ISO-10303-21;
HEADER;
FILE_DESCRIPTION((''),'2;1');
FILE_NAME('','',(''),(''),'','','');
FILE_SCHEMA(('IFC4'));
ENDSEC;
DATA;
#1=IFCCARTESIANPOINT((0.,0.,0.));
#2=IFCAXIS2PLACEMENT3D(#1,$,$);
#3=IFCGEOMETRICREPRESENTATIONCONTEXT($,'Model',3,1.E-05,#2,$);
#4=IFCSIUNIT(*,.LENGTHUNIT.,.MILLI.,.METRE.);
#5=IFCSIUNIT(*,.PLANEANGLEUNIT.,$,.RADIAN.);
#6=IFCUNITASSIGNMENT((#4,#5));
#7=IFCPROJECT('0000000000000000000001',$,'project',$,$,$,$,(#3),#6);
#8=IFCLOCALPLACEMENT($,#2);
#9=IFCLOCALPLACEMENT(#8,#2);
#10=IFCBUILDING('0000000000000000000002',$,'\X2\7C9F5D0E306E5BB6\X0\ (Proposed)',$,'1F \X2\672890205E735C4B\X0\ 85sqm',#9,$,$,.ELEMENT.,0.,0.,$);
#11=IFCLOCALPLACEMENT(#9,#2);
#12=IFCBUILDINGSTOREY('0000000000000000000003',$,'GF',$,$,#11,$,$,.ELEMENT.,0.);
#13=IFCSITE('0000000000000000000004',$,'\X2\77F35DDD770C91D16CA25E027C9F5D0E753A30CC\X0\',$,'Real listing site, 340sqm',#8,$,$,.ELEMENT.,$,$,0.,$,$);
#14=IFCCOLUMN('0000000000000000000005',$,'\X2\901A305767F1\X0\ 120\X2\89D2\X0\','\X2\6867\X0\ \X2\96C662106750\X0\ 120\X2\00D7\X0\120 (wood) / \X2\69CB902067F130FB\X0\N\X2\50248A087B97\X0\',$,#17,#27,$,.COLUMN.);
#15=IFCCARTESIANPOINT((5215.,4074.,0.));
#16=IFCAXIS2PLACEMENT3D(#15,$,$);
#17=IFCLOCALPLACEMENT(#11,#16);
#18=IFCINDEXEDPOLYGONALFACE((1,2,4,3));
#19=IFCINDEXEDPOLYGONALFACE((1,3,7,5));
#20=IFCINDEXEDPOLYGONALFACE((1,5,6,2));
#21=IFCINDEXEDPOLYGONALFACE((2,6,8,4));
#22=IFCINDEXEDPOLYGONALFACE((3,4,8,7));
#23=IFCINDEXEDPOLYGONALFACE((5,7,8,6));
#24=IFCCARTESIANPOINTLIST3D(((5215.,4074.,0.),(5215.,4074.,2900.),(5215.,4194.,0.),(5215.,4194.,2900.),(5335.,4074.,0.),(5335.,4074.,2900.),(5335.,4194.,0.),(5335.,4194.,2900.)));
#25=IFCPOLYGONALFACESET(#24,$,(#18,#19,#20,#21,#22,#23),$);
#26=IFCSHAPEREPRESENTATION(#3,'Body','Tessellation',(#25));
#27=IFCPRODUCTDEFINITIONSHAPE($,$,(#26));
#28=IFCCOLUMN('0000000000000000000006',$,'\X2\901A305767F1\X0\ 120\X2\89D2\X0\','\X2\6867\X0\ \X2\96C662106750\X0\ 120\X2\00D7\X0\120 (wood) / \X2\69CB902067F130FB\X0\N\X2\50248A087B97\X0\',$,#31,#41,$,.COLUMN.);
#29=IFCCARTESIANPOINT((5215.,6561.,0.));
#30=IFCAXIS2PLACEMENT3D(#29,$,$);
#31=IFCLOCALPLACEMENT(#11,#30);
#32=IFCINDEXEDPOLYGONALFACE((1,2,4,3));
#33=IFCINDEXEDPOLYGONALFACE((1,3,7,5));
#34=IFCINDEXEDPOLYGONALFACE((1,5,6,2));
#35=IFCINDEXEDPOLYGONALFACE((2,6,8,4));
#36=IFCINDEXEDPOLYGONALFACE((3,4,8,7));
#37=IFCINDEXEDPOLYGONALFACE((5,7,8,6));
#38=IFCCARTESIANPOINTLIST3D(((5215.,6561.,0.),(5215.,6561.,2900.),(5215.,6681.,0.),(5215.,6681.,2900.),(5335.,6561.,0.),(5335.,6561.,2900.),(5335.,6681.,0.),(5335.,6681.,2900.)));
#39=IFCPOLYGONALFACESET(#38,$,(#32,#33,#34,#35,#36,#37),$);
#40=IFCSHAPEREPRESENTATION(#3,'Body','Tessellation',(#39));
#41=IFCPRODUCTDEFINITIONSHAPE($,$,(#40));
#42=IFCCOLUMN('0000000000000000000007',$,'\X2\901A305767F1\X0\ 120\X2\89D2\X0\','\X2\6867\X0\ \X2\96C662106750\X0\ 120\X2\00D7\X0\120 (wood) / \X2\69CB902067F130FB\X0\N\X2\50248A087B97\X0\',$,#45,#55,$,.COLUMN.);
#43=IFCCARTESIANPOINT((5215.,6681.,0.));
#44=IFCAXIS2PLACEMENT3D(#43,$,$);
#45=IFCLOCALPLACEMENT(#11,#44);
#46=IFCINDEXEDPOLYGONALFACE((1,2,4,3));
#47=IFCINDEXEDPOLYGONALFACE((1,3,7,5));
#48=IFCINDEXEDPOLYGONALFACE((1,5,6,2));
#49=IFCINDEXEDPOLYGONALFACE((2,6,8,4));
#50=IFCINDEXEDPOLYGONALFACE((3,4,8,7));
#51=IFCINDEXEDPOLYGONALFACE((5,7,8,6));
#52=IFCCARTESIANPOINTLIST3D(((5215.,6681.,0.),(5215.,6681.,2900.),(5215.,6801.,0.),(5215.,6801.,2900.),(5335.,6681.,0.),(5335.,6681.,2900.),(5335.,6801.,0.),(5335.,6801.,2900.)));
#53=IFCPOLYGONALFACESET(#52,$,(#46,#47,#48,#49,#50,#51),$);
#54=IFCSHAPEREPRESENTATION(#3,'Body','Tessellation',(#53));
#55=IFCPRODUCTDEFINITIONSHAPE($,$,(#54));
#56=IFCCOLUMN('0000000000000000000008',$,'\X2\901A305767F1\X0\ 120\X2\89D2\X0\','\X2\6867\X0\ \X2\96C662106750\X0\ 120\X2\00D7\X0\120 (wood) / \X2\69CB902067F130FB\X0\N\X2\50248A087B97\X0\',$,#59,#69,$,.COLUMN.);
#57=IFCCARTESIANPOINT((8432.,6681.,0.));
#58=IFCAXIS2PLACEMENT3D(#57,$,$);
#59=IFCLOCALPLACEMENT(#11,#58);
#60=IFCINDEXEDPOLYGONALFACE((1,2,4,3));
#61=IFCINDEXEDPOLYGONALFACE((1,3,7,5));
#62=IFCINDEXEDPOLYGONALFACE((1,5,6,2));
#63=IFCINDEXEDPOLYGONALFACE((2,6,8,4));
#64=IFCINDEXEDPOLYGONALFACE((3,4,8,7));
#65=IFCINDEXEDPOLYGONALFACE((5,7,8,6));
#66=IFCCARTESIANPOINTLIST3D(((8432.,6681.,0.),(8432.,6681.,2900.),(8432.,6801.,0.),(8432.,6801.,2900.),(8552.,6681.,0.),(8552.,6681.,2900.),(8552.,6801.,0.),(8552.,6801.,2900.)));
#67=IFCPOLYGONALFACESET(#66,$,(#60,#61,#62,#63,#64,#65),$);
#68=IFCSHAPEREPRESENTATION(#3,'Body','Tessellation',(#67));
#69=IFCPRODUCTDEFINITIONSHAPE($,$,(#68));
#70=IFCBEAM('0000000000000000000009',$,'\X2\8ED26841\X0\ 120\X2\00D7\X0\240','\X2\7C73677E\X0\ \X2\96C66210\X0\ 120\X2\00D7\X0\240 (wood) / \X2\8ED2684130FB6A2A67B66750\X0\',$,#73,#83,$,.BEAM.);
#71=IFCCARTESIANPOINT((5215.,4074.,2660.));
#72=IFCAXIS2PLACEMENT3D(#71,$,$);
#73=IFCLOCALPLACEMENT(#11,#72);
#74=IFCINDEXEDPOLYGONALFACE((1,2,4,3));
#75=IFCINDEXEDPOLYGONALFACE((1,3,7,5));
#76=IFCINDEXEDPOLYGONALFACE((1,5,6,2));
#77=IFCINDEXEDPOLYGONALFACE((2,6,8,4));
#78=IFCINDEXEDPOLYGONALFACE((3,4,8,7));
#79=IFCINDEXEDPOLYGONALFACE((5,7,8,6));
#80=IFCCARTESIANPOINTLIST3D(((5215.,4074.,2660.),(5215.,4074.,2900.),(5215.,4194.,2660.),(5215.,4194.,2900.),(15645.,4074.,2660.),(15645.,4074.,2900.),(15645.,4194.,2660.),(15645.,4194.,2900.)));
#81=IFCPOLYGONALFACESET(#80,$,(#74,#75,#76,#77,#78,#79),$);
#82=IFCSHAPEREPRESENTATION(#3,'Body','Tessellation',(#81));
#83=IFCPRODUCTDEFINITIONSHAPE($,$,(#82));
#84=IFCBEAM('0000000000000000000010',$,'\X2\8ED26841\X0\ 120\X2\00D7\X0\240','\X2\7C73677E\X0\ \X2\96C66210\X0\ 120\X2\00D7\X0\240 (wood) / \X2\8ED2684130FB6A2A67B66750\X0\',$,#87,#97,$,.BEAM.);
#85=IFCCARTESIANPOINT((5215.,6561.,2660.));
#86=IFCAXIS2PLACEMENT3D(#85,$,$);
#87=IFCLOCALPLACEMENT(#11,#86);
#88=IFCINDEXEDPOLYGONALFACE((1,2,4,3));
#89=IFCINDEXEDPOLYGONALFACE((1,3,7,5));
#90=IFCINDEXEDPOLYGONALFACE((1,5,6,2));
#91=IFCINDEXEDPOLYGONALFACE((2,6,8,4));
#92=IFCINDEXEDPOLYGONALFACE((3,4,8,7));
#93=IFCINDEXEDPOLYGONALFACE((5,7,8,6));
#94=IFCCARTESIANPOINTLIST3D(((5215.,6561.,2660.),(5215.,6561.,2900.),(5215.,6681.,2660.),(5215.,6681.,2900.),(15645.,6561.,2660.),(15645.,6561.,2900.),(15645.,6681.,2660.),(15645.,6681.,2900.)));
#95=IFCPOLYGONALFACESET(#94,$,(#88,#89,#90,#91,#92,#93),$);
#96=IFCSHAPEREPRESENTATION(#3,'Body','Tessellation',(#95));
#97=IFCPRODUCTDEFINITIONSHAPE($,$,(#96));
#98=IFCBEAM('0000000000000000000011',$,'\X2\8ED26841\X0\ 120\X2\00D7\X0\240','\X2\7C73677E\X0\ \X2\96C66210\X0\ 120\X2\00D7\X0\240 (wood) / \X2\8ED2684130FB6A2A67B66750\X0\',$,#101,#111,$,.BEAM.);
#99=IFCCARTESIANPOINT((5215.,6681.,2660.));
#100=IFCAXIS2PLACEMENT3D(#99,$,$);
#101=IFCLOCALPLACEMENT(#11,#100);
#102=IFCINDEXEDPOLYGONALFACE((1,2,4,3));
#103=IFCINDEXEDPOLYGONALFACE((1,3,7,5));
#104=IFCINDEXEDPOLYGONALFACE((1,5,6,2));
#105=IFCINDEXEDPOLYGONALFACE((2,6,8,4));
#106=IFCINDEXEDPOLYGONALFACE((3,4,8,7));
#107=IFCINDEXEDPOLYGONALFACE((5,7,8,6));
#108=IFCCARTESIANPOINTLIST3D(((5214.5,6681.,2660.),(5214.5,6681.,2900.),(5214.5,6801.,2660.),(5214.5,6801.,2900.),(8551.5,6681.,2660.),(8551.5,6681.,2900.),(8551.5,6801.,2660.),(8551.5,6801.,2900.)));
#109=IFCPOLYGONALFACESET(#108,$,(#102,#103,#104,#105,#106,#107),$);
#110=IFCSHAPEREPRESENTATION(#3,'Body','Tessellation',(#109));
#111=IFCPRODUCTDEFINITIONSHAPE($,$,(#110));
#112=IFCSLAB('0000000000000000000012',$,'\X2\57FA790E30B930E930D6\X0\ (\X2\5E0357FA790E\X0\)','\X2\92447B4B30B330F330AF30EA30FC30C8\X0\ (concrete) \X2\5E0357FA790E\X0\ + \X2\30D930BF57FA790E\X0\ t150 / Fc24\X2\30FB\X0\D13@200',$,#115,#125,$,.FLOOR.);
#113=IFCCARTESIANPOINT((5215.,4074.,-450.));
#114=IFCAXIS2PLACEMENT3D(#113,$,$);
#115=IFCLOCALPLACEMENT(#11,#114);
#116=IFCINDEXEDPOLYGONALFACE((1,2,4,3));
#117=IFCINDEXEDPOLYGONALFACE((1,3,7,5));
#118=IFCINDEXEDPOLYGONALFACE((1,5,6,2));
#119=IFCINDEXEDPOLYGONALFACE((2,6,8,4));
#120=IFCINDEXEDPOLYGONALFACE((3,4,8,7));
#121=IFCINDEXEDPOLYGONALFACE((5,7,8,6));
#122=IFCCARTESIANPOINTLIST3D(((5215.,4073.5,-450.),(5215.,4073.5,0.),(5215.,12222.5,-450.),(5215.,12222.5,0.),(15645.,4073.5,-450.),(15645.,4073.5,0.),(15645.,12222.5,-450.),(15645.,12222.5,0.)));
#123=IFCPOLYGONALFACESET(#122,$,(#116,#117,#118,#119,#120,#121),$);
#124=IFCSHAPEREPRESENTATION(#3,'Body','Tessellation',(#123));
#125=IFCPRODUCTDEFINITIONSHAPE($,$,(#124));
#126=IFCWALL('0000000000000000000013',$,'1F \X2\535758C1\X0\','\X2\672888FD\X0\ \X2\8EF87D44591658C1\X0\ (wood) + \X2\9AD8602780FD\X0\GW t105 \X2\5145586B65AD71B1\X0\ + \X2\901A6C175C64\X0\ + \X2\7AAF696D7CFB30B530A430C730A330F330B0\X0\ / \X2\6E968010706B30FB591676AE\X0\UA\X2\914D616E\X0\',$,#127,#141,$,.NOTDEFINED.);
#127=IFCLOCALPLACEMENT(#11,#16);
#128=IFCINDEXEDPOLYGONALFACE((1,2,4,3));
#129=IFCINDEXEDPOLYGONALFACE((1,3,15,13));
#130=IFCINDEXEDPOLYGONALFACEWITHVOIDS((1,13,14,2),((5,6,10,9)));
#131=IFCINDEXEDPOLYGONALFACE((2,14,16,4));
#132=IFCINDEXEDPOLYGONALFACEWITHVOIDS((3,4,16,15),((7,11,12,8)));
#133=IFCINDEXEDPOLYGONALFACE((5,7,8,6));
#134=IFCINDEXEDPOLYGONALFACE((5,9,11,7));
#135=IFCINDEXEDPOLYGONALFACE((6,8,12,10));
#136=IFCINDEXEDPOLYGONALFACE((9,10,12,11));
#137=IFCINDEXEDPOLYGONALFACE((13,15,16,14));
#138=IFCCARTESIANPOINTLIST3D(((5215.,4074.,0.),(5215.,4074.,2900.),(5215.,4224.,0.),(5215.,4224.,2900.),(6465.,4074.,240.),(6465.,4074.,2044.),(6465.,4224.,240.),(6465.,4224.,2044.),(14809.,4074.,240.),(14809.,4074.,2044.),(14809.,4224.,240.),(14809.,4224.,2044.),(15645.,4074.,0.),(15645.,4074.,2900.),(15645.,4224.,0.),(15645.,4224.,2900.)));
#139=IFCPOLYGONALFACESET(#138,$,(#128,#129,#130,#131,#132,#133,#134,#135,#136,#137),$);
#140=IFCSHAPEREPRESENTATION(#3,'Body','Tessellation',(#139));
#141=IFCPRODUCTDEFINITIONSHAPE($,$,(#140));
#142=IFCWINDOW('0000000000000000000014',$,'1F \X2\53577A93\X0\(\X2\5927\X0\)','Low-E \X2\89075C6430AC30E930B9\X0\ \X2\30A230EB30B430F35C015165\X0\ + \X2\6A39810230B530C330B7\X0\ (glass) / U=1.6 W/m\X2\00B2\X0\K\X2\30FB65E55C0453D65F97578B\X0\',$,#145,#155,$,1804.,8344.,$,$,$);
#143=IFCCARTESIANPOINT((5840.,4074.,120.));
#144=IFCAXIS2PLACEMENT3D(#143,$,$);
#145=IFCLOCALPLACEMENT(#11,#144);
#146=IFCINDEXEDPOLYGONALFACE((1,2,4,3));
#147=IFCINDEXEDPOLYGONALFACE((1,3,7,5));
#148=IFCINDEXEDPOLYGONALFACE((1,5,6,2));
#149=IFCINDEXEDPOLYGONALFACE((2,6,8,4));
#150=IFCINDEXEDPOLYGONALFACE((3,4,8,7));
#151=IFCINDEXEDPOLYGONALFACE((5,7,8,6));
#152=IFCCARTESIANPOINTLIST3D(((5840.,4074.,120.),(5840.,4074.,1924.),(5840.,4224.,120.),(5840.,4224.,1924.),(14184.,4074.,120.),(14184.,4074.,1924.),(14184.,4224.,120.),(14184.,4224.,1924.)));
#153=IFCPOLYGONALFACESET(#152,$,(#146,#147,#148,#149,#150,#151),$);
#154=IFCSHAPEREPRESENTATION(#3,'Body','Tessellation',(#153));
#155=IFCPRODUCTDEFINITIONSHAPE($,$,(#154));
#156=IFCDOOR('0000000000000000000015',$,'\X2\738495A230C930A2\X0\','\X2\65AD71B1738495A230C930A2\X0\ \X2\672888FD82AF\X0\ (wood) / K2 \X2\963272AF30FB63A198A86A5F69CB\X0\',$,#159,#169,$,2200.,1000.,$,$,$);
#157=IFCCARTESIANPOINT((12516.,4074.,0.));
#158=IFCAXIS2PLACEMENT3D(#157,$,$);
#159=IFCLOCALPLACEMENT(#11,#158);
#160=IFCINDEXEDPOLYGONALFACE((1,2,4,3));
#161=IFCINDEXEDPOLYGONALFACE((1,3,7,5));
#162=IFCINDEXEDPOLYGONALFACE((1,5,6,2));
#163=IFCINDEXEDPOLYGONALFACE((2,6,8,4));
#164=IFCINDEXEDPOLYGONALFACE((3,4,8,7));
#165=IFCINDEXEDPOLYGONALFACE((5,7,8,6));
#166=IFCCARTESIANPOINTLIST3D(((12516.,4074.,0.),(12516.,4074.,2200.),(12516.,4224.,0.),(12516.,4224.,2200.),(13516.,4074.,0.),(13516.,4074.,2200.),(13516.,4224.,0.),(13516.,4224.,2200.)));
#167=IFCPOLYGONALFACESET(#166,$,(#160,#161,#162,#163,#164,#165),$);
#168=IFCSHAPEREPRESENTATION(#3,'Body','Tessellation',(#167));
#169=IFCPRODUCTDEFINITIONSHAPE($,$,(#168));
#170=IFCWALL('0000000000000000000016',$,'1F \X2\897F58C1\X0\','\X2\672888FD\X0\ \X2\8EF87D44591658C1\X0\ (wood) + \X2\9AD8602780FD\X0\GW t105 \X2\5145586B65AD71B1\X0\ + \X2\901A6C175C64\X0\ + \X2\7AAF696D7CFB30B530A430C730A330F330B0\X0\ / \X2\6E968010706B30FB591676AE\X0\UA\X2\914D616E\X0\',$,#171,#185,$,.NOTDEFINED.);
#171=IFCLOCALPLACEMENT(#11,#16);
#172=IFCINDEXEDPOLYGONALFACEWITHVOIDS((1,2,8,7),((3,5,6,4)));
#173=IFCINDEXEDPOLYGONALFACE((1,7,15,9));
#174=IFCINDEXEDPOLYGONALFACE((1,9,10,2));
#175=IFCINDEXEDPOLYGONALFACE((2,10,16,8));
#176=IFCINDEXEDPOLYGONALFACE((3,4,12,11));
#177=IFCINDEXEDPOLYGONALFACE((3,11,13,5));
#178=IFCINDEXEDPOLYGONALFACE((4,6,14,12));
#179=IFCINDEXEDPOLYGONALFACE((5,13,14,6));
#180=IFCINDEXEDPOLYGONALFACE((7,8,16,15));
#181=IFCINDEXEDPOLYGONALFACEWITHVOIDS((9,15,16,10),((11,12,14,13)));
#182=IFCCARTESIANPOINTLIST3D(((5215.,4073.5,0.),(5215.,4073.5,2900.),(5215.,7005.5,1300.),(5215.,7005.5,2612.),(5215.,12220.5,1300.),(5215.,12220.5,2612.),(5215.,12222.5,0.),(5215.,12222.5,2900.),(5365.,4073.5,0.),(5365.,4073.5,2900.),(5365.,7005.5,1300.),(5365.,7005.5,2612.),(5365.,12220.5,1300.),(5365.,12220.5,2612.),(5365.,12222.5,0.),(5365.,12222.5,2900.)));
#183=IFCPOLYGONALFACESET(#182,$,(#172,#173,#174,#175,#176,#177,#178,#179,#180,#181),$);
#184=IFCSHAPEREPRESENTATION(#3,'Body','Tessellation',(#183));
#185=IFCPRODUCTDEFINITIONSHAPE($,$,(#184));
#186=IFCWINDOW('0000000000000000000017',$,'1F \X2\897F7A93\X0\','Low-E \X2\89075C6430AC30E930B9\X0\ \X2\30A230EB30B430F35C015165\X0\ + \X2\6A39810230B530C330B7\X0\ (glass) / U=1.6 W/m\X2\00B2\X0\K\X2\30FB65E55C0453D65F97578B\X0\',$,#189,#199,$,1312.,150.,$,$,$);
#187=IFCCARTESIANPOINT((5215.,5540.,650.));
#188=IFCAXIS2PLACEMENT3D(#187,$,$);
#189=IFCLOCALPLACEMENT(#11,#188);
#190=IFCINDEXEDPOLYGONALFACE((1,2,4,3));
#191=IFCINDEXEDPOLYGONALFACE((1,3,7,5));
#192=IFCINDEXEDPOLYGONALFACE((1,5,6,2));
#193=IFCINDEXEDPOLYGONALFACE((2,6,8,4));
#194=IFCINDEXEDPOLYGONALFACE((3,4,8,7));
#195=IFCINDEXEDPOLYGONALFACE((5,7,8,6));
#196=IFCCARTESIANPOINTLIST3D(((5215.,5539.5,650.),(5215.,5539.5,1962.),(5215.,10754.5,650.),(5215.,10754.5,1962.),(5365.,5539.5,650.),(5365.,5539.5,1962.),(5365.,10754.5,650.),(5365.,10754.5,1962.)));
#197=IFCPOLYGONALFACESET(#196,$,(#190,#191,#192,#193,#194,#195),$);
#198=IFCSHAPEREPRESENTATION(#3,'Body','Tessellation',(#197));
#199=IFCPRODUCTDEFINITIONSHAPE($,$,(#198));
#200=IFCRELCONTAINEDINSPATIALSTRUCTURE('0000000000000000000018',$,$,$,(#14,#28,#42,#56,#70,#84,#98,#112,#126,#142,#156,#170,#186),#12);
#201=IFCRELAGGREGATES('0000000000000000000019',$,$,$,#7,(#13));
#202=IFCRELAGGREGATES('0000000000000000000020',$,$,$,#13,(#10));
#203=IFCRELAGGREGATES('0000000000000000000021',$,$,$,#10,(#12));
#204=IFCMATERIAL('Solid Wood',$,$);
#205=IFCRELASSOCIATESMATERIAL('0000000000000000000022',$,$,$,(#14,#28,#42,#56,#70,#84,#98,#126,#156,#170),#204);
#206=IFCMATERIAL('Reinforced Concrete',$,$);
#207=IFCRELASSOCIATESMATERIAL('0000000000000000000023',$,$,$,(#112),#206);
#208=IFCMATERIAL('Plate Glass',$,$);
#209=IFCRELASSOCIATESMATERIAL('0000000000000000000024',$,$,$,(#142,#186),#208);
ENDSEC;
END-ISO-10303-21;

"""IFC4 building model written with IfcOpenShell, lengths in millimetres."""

from ifc_helpers import new_model, si_unit, frame, frame_2d, origin, place, context, project, spatial, rectangle, extrude, material, element, fill, save


model = new_model("IFC4")

# Units and contexts
model_context = context("Model", 3, precision=1e-05, world=origin())
ifc_project = project(units=[si_unit("LENGTHUNIT", "METRE", prefix="MILLI"), si_unit("PLANEANGLEUNIT", "RADIAN")], contexts=[model_context])

# Site, building, storey
site_placement = place(None, origin())
site = spatial("IfcSite", under=ifc_project, at=site_placement, Name="石川県金沢市粟崎町ヌ", ObjectType="Real listing site, 340sqm", CompositionType="ELEMENT", RefElevation=0.0)
building_placement = place(site_placement, origin())
building = spatial("IfcBuilding", under=site, at=building_placement, Name="粟崎の家 (Proposed)", ObjectType="1F 木造平屋 85sqm", CompositionType="ELEMENT", ElevationOfRefHeight=0.0, ElevationOfTerrain=0.0)
storey_placement = place(building_placement, origin())
storey = spatial("IfcBuildingStorey", under=building, at=storey_placement, Name="GF", CompositionType="ELEMENT", Elevation=0.0)

# Columns
ifc_material_1 = material(Name="Solid Wood")
column_1_placement = place(storey_placement, frame((5215.0, 4074.0, 0.0)))
element("IfcColumn", 1, at=column_1_placement, inside=storey, material=ifc_material_1, Name="通し柱 120角", Description="桧 集成材 120×120 (wood) / 構造柱・N値計算", PredefinedType="COLUMN", context=model_context, shape_type="SweptSolid", body=[
    extrude(rectangle(XDim=120.0, YDim=120.0, at=frame_2d((60.0, 60.0))), frame((5215.0, 4074.0, 0.0)), (0.0, 0.0, 1.0), 2900.0),
])
column_2_placement = place(storey_placement, frame((5215.0, 6561.0, 0.0)))
element("IfcColumn", 2, at=column_2_placement, inside=storey, material=ifc_material_1, Name="通し柱 120角", Description="桧 集成材 120×120 (wood) / 構造柱・N値計算", PredefinedType="COLUMN", context=model_context, shape_type="SweptSolid", body=[
    extrude(rectangle(XDim=120.0, YDim=120.0, at=frame_2d((60.0, 60.0))), frame((5215.0, 6561.0, 0.0)), (0.0, 0.0, 1.0), 2900.0),
])
column_3_placement = place(storey_placement, frame((5215.0, 6681.0, 0.0)))
element("IfcColumn", 3, at=column_3_placement, inside=storey, material=ifc_material_1, Name="通し柱 120角", Description="桧 集成材 120×120 (wood) / 構造柱・N値計算", PredefinedType="COLUMN", context=model_context, shape_type="SweptSolid", body=[
    extrude(rectangle(XDim=120.0, YDim=120.0, at=frame_2d((60.0, 60.0))), frame((5215.0, 6681.0, 0.0)), (0.0, 0.0, 1.0), 2900.0),
])
column_4_placement = place(storey_placement, frame((8432.0, 6681.0, 0.0)))
element("IfcColumn", 4, at=column_4_placement, inside=storey, material=ifc_material_1, Name="通し柱 120角", Description="桧 集成材 120×120 (wood) / 構造柱・N値計算", PredefinedType="COLUMN", context=model_context, shape_type="SweptSolid", body=[
    extrude(rectangle(XDim=120.0, YDim=120.0, at=frame_2d((60.0, 60.0))), frame((8432.0, 6681.0, 0.0)), (0.0, 0.0, 1.0), 2900.0),
])

# Beams
beam_1_placement = place(storey_placement, frame((5215.0, 4074.0, 2660.0)))
element("IfcBeam", 5, at=beam_1_placement, inside=storey, material=ifc_material_1, Name="軒桁 120×240", Description="米松 集成 120×240 (wood) / 軒桁・横架材", PredefinedType="BEAM", context=model_context, shape_type="SweptSolid", body=[
    extrude(rectangle(XDim=10430.0, YDim=120.0, at=frame_2d((5215.0, 60.0))), frame((5215.0, 4074.0, 2660.0)), (0.0, 0.0, 1.0), 240.0),
])
beam_2_placement = place(storey_placement, frame((5215.0, 6561.0, 2660.0)))
element("IfcBeam", 6, at=beam_2_placement, inside=storey, material=ifc_material_1, Name="軒桁 120×240", Description="米松 集成 120×240 (wood) / 軒桁・横架材", PredefinedType="BEAM", context=model_context, shape_type="SweptSolid", body=[
    extrude(rectangle(XDim=10430.0, YDim=120.0, at=frame_2d((5215.0, 60.0))), frame((5215.0, 6561.0, 2660.0)), (0.0, 0.0, 1.0), 240.0),
])
beam_3_placement = place(storey_placement, frame((5215.0, 6681.0, 2660.0)))
element("IfcBeam", 7, at=beam_3_placement, inside=storey, material=ifc_material_1, Name="軒桁 120×240", Description="米松 集成 120×240 (wood) / 軒桁・横架材", PredefinedType="BEAM", context=model_context, shape_type="SweptSolid", body=[
    extrude(rectangle(XDim=3337.0, YDim=120.0, at=frame_2d((1668.0, 60.0))), frame((5215.0, 6681.0, 2660.0)), (0.0, 0.0, 1.0), 240.0),
])

# Slab
ifc_material_2 = material(Name="Reinforced Concrete")
slab_1_placement = place(storey_placement, frame((5215.0, 4074.0, -450.0)))
element("IfcSlab", 8, at=slab_1_placement, inside=storey, material=ifc_material_2, Name="基礎スラブ (布基礎)", Description="鉄筋コンクリート (concrete) 布基礎 + ベタ基礎 t150 / Fc24・D13@200", PredefinedType="FLOOR", context=model_context, shape_type="SweptSolid", body=[
    extrude(rectangle(XDim=10430.0, YDim=8149.0, at=frame_2d((5215.0, 4074.0))), frame((5215.0, 4074.0, -450.0)), (0.0, 0.0, 1.0), 450.0),
])

# Wall, openings, window, door
wall_1_placement = place(storey_placement, frame((5215.0, 4074.0, 0.0)))
wall_1 = element("IfcWall", 9, at=wall_1_placement, inside=storey, material=ifc_material_1, Name="1F 南壁", Description="木製 軸組外壁 (wood) + 高性能GW t105 充填断熱 + 通気層 + 窯業系サイディング / 準耐火・外皮UA配慮", PredefinedType="NOTDEFINED", context=model_context, shape_type="SweptSolid", body=[
    extrude(rectangle(XDim=10430.0, YDim=150.0, at=frame_2d((5215.0, 75.0))), frame((5215.0, 4074.0, 0.0)), (0.0, 0.0, 1.0), 2900.0),
])
opening_1_placement = place(storey_placement, frame((5840.0, 4074.0, 120.0)))
opening_1 = element("IfcOpeningElement", 10, at=opening_1_placement, cuts=wall_1, PredefinedType="NOTDEFINED", context=model_context, shape_type="SweptSolid", body=[
    extrude(rectangle(XDim=8344.0, YDim=150.0, at=frame_2d((4172.0, 75.0))), frame((5840.0, 4074.0, 120.0)), (0.0, 0.0, 1.0), 1804.0),
])
opening_2_placement = place(storey_placement, frame((12516.0, 4074.0, 0.0)))
opening_2 = element("IfcOpeningElement", 11, at=opening_2_placement, cuts=wall_1, PredefinedType="NOTDEFINED", context=model_context, shape_type="SweptSolid", body=[
    extrude(rectangle(XDim=1000.0, YDim=150.0, at=frame_2d((500.0, 75.0))), frame((12516.0, 4074.0, 0.0)), (0.0, 0.0, 1.0), 2200.0),
])
ifc_material_3 = material(Name="Plate Glass")
window_1_placement = place(storey_placement, frame((5840.0, 4074.0, 120.0)))
window_1 = element("IfcWindow", 12, at=window_1_placement, inside=storey, material=ifc_material_3, Name="1F 南窓(大)", Description="Low-E 複層ガラス アルゴン封入 + 樹脂サッシ (glass) / U=1.6 W/m²K・日射取得型", OverallHeight=1804.0, OverallWidth=8344.0, context=model_context, shape_type="SweptSolid", body=[
    extrude(rectangle(XDim=8344.0, YDim=150.0, at=frame_2d((4172.0, 75.0))), frame((5840.0, 4074.0, 120.0)), (0.0, 0.0, 1.0), 1804.0),
])
fill(opening_1, window_1)
door_placement = place(storey_placement, frame((12516.0, 4074.0, 0.0)))
door = element("IfcDoor", 13, at=door_placement, inside=storey, material=ifc_material_1, Name="玄関ドア", Description="断熱玄関ドア 木製芯 (wood) / K2 防犯・採風機構", OverallHeight=2200.0, OverallWidth=1000.0, context=model_context, shape_type="SweptSolid", body=[
    extrude(rectangle(XDim=1000.0, YDim=150.0, at=frame_2d((500.0, 75.0))), frame((12516.0, 4074.0, 0.0)), (0.0, 0.0, 1.0), 2200.0),
])
fill(opening_2, door)

# Wall, opening, window
wall_2_placement = place(storey_placement, frame((5215.0, 4074.0, 0.0)))
wall_2 = element("IfcWall", 14, at=wall_2_placement, inside=storey, material=ifc_material_1, Name="1F 西壁", Description="木製 軸組外壁 (wood) + 高性能GW t105 充填断熱 + 通気層 + 窯業系サイディング / 準耐火・外皮UA配慮", PredefinedType="NOTDEFINED", context=model_context, shape_type="SweptSolid", body=[
    extrude(rectangle(XDim=150.0, YDim=8149.0, at=frame_2d((75.0, 4074.0))), frame((5215.0, 4074.0, 0.0)), (0.0, 0.0, 1.0), 2900.0),
])
opening_3_placement = place(storey_placement, frame((5215.0, 5540.0, 650.0)))
opening_3 = element("IfcOpeningElement", 15, at=opening_3_placement, cuts=wall_2, PredefinedType="NOTDEFINED", context=model_context, shape_type="SweptSolid", body=[
    extrude(rectangle(XDim=150.0, YDim=5215.0, at=frame_2d((75.0, 2607.0))), frame((5215.0, 5540.0, 650.0)), (0.0, 0.0, 1.0), 1312.0),
])
window_2_placement = place(storey_placement, frame((5215.0, 5540.0, 650.0)))
window_2 = element("IfcWindow", 16, at=window_2_placement, inside=storey, material=ifc_material_3, Name="1F 西窓", Description="Low-E 複層ガラス アルゴン封入 + 樹脂サッシ (glass) / U=1.6 W/m²K・日射取得型", OverallHeight=1312.0, OverallWidth=150.0, context=model_context, shape_type="SweptSolid", body=[
    extrude(rectangle(XDim=150.0, YDim=5215.0, at=frame_2d((75.0, 2607.0))), frame((5215.0, 5540.0, 650.0)), (0.0, 0.0, 1.0), 1312.0),
])
fill(opening_3, window_2)

save(model, "model.ifc")
